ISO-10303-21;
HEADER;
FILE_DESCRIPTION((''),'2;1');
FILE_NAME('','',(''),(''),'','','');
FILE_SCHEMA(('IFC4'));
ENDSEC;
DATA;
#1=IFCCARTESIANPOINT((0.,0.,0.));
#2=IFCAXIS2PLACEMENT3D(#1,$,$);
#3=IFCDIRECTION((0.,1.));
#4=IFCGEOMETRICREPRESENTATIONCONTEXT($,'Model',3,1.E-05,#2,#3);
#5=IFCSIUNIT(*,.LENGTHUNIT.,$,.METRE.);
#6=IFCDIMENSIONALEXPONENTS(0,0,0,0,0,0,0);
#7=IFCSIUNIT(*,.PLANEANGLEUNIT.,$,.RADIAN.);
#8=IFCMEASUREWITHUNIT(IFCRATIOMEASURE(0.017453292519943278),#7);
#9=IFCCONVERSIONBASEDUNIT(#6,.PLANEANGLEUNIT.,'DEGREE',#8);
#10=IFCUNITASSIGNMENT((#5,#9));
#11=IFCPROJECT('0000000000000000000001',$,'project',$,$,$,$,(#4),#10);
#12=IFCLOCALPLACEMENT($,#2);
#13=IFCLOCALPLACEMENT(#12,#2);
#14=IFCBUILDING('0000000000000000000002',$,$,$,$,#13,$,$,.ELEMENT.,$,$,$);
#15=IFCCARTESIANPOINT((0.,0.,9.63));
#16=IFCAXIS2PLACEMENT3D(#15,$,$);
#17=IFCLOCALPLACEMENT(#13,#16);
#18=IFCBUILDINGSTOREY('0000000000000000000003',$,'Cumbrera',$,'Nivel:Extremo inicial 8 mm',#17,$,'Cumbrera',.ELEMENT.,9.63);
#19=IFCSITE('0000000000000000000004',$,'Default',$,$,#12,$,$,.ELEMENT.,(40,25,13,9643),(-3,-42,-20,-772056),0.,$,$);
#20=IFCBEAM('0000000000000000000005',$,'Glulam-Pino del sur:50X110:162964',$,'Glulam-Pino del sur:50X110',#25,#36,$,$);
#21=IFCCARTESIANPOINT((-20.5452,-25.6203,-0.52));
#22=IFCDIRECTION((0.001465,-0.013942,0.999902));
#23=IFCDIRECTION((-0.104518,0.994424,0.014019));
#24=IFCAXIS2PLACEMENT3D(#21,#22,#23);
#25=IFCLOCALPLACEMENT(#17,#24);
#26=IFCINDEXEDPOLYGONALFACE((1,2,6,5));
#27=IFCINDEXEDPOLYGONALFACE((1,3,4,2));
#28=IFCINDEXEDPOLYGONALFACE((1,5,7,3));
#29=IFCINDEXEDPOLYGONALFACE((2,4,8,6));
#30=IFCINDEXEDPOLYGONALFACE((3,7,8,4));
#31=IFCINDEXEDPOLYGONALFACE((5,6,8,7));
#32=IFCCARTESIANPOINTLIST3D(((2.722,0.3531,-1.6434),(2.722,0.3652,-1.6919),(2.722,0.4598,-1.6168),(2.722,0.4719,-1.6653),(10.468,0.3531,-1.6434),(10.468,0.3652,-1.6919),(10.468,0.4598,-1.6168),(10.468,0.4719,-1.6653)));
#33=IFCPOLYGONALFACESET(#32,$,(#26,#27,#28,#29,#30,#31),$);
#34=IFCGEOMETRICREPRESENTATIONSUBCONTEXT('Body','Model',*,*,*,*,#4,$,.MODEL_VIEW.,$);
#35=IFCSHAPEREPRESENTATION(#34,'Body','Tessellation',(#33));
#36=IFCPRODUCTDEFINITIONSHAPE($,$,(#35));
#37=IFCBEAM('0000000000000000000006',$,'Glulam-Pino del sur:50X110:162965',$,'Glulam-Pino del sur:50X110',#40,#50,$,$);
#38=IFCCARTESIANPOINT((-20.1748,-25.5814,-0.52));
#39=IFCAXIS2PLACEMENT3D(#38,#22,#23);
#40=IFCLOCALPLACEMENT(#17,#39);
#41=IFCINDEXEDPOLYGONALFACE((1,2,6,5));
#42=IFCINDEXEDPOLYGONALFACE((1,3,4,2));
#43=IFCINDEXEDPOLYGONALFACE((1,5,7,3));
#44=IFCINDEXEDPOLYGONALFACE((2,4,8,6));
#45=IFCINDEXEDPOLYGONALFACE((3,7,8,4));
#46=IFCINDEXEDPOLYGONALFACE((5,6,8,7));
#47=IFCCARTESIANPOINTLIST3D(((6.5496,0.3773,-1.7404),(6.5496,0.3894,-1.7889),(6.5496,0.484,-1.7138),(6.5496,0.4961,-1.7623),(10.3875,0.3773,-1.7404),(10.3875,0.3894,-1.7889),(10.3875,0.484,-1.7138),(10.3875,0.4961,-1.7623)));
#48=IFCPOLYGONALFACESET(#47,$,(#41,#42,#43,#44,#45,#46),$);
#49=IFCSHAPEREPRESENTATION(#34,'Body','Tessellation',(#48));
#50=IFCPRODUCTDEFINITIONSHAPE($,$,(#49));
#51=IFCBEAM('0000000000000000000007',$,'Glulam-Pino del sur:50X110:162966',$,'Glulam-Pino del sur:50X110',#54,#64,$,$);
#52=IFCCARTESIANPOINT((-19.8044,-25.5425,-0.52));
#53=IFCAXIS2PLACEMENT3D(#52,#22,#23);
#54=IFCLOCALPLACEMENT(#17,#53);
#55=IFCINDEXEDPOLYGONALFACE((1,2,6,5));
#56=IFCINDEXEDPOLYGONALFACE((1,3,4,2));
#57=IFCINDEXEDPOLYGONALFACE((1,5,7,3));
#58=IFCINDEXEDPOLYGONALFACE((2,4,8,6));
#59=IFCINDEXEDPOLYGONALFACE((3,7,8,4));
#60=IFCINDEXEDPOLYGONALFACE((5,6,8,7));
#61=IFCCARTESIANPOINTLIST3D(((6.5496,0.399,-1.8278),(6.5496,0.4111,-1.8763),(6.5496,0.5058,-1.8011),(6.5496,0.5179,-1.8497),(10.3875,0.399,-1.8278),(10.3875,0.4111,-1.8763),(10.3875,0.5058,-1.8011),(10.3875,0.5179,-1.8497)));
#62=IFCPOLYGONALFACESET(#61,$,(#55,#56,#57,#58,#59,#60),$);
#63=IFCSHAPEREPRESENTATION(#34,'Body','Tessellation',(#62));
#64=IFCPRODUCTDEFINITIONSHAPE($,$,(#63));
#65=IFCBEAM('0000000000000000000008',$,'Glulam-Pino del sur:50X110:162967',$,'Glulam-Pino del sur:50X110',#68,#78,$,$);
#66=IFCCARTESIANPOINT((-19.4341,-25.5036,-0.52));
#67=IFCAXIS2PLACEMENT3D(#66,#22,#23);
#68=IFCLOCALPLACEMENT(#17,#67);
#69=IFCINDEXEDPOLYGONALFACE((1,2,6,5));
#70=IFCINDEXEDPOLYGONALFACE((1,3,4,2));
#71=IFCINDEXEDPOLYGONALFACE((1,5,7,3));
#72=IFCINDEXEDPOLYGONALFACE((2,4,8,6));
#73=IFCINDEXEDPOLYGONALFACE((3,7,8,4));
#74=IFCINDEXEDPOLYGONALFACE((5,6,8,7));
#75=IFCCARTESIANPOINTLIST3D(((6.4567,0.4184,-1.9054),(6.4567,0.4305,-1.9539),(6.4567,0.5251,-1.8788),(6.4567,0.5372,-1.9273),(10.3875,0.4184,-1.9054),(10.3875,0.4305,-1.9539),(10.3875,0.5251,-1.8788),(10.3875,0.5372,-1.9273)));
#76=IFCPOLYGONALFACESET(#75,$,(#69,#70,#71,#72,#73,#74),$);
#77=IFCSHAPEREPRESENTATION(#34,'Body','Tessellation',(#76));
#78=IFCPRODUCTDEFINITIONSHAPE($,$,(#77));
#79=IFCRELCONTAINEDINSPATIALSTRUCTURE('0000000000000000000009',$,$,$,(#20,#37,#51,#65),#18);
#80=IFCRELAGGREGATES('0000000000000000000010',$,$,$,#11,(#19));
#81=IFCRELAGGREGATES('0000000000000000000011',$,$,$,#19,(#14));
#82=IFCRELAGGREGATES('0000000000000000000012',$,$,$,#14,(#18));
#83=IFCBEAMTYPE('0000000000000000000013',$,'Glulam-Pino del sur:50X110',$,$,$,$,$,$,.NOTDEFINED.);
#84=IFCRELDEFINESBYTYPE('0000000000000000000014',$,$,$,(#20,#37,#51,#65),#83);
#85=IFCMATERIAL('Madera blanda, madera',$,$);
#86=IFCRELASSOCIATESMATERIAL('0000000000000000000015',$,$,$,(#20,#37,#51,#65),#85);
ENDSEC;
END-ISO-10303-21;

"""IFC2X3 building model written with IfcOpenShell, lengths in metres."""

from ifc_helpers import new_model, entity, si_unit, converted_unit, direction, frame, frame_2d, origin, place, context, subcontext, project, spatial, rectangle, extrude, material, type_object, element, save


model = new_model("IFC2X3")

# Units and contexts
model_context = context("Model", 3, precision=1e-05, world=origin(), true_north=direction((0.0, 1.0)))
body_context = subcontext(model_context, "Body", "Model", "MODEL_VIEW")
ifc_project = project(units=[si_unit("LENGTHUNIT", "METRE"), converted_unit("PLANEANGLEUNIT", "DEGREE", entity("IfcRatioMeasure", 0.017453292519943278), si_unit("PLANEANGLEUNIT", "RADIAN"), dimensions=[0, 0, 0, 0, 0, 0, 0])], contexts=[model_context])

# Site, building, storey
site_placement = place(None, origin())
site = spatial("IfcSite", under=ifc_project, at=site_placement, Name="Default", CompositionType="ELEMENT", RefLatitude=(40, 25, 13, 9643), RefLongitude=(-3, -42, -20, -772056), RefElevation=0.0)
building_placement = place(site_placement, origin())
building = spatial("IfcBuilding", under=site, at=building_placement, CompositionType="ELEMENT")
storey_placement = place(building_placement, frame((0.0, 0.0, 9.63)))
storey = spatial("IfcBuildingStorey", under=building, at=storey_placement, Name="Cumbrera", ObjectType="Nivel:Extremo inicial 8 mm", LongName="Cumbrera", CompositionType="ELEMENT", Elevation=9.63)

# Beams
ifc_material_1 = material(Name="Madera blanda, madera")
beam_type = type_object("IfcBeamType", Name="Glulam-Pino del sur:50X110", PredefinedType="NOTDEFINED")
beam_1_placement = place(storey_placement, frame((-20.5452, -25.6203, -0.52), z_axis=(0.001465, -0.013942, 0.999902), x_axis=(-0.104518, 0.994424, 0.014019)))
element("IfcBeam", 1, at=beam_1_placement, inside=storey, type_object=beam_type, material=ifc_material_1, Name="Glulam-Pino del sur:50X110:162964", ObjectType="Glulam-Pino del sur:50X110", context=body_context, shape_type="SweptSolid", body=[
    extrude(rectangle(XDim=0.05, YDim=0.11, at=frame_2d((0.0, 0.0), x_axis=(0.0, 1.0))), frame((2.722, 0.4125, -1.6544), z_axis=(1.0, 0.0, 0.0), x_axis=(0.0, -0.970296, -0.241922)), (0.0, 0.0, 1.0), 7.746),
])
beam_2_placement = place(storey_placement, frame((-20.1748, -25.5814, -0.52), z_axis=(0.001465, -0.013942, 0.999902), x_axis=(-0.104518, 0.994424, 0.014019)))
element("IfcBeam", 2, at=beam_2_placement, inside=storey, type_object=beam_type, material=ifc_material_1, Name="Glulam-Pino del sur:50X110:162965", ObjectType="Glulam-Pino del sur:50X110", context=body_context, shape_type="SweptSolid", body=[
    extrude(rectangle(XDim=0.05, YDim=0.11, at=frame_2d((0.0, 0.0), x_axis=(0.0, 1.0))), frame((6.5496, 0.4367, -1.7514), z_axis=(1.0, 0.0, 0.0), x_axis=(0.0, -0.970296, -0.241922)), (0.0, 0.0, 1.0), 3.8379),
])
beam_3_placement = place(storey_placement, frame((-19.8044, -25.5425, -0.52), z_axis=(0.001465, -0.013942, 0.999902), x_axis=(-0.104518, 0.994424, 0.014019)))
element("IfcBeam", 3, at=beam_3_placement, inside=storey, type_object=beam_type, material=ifc_material_1, Name="Glulam-Pino del sur:50X110:162966", ObjectType="Glulam-Pino del sur:50X110", context=body_context, shape_type="SweptSolid", body=[
    extrude(rectangle(XDim=0.05, YDim=0.11, at=frame_2d((0.0, 0.0), x_axis=(0.0, 1.0))), frame((6.5496, 0.4584, -1.8387), z_axis=(1.0, 0.0, 0.0), x_axis=(0.0, -0.970296, -0.241922)), (0.0, 0.0, 1.0), 3.8379),
])
beam_4_placement = place(storey_placement, frame((-19.4341, -25.5036, -0.52), z_axis=(0.001465, -0.013942, 0.999902), x_axis=(-0.104518, 0.994424, 0.014019)))
element("IfcBeam", 4, at=beam_4_placement, inside=storey, type_object=beam_type, material=ifc_material_1, Name="Glulam-Pino del sur:50X110:162967", ObjectType="Glulam-Pino del sur:50X110", context=body_context, shape_type="SweptSolid", body=[
    extrude(rectangle(XDim=0.05, YDim=0.11, at=frame_2d((0.0, 0.0), x_axis=(0.0, 1.0))), frame((6.4567, 0.4778, -1.9163), z_axis=(1.0, 0.0, 0.0), x_axis=(0.0, -0.970296, -0.241922)), (0.0, 0.0, 1.0), 3.9308),
])

save(model, "model.ifc")
